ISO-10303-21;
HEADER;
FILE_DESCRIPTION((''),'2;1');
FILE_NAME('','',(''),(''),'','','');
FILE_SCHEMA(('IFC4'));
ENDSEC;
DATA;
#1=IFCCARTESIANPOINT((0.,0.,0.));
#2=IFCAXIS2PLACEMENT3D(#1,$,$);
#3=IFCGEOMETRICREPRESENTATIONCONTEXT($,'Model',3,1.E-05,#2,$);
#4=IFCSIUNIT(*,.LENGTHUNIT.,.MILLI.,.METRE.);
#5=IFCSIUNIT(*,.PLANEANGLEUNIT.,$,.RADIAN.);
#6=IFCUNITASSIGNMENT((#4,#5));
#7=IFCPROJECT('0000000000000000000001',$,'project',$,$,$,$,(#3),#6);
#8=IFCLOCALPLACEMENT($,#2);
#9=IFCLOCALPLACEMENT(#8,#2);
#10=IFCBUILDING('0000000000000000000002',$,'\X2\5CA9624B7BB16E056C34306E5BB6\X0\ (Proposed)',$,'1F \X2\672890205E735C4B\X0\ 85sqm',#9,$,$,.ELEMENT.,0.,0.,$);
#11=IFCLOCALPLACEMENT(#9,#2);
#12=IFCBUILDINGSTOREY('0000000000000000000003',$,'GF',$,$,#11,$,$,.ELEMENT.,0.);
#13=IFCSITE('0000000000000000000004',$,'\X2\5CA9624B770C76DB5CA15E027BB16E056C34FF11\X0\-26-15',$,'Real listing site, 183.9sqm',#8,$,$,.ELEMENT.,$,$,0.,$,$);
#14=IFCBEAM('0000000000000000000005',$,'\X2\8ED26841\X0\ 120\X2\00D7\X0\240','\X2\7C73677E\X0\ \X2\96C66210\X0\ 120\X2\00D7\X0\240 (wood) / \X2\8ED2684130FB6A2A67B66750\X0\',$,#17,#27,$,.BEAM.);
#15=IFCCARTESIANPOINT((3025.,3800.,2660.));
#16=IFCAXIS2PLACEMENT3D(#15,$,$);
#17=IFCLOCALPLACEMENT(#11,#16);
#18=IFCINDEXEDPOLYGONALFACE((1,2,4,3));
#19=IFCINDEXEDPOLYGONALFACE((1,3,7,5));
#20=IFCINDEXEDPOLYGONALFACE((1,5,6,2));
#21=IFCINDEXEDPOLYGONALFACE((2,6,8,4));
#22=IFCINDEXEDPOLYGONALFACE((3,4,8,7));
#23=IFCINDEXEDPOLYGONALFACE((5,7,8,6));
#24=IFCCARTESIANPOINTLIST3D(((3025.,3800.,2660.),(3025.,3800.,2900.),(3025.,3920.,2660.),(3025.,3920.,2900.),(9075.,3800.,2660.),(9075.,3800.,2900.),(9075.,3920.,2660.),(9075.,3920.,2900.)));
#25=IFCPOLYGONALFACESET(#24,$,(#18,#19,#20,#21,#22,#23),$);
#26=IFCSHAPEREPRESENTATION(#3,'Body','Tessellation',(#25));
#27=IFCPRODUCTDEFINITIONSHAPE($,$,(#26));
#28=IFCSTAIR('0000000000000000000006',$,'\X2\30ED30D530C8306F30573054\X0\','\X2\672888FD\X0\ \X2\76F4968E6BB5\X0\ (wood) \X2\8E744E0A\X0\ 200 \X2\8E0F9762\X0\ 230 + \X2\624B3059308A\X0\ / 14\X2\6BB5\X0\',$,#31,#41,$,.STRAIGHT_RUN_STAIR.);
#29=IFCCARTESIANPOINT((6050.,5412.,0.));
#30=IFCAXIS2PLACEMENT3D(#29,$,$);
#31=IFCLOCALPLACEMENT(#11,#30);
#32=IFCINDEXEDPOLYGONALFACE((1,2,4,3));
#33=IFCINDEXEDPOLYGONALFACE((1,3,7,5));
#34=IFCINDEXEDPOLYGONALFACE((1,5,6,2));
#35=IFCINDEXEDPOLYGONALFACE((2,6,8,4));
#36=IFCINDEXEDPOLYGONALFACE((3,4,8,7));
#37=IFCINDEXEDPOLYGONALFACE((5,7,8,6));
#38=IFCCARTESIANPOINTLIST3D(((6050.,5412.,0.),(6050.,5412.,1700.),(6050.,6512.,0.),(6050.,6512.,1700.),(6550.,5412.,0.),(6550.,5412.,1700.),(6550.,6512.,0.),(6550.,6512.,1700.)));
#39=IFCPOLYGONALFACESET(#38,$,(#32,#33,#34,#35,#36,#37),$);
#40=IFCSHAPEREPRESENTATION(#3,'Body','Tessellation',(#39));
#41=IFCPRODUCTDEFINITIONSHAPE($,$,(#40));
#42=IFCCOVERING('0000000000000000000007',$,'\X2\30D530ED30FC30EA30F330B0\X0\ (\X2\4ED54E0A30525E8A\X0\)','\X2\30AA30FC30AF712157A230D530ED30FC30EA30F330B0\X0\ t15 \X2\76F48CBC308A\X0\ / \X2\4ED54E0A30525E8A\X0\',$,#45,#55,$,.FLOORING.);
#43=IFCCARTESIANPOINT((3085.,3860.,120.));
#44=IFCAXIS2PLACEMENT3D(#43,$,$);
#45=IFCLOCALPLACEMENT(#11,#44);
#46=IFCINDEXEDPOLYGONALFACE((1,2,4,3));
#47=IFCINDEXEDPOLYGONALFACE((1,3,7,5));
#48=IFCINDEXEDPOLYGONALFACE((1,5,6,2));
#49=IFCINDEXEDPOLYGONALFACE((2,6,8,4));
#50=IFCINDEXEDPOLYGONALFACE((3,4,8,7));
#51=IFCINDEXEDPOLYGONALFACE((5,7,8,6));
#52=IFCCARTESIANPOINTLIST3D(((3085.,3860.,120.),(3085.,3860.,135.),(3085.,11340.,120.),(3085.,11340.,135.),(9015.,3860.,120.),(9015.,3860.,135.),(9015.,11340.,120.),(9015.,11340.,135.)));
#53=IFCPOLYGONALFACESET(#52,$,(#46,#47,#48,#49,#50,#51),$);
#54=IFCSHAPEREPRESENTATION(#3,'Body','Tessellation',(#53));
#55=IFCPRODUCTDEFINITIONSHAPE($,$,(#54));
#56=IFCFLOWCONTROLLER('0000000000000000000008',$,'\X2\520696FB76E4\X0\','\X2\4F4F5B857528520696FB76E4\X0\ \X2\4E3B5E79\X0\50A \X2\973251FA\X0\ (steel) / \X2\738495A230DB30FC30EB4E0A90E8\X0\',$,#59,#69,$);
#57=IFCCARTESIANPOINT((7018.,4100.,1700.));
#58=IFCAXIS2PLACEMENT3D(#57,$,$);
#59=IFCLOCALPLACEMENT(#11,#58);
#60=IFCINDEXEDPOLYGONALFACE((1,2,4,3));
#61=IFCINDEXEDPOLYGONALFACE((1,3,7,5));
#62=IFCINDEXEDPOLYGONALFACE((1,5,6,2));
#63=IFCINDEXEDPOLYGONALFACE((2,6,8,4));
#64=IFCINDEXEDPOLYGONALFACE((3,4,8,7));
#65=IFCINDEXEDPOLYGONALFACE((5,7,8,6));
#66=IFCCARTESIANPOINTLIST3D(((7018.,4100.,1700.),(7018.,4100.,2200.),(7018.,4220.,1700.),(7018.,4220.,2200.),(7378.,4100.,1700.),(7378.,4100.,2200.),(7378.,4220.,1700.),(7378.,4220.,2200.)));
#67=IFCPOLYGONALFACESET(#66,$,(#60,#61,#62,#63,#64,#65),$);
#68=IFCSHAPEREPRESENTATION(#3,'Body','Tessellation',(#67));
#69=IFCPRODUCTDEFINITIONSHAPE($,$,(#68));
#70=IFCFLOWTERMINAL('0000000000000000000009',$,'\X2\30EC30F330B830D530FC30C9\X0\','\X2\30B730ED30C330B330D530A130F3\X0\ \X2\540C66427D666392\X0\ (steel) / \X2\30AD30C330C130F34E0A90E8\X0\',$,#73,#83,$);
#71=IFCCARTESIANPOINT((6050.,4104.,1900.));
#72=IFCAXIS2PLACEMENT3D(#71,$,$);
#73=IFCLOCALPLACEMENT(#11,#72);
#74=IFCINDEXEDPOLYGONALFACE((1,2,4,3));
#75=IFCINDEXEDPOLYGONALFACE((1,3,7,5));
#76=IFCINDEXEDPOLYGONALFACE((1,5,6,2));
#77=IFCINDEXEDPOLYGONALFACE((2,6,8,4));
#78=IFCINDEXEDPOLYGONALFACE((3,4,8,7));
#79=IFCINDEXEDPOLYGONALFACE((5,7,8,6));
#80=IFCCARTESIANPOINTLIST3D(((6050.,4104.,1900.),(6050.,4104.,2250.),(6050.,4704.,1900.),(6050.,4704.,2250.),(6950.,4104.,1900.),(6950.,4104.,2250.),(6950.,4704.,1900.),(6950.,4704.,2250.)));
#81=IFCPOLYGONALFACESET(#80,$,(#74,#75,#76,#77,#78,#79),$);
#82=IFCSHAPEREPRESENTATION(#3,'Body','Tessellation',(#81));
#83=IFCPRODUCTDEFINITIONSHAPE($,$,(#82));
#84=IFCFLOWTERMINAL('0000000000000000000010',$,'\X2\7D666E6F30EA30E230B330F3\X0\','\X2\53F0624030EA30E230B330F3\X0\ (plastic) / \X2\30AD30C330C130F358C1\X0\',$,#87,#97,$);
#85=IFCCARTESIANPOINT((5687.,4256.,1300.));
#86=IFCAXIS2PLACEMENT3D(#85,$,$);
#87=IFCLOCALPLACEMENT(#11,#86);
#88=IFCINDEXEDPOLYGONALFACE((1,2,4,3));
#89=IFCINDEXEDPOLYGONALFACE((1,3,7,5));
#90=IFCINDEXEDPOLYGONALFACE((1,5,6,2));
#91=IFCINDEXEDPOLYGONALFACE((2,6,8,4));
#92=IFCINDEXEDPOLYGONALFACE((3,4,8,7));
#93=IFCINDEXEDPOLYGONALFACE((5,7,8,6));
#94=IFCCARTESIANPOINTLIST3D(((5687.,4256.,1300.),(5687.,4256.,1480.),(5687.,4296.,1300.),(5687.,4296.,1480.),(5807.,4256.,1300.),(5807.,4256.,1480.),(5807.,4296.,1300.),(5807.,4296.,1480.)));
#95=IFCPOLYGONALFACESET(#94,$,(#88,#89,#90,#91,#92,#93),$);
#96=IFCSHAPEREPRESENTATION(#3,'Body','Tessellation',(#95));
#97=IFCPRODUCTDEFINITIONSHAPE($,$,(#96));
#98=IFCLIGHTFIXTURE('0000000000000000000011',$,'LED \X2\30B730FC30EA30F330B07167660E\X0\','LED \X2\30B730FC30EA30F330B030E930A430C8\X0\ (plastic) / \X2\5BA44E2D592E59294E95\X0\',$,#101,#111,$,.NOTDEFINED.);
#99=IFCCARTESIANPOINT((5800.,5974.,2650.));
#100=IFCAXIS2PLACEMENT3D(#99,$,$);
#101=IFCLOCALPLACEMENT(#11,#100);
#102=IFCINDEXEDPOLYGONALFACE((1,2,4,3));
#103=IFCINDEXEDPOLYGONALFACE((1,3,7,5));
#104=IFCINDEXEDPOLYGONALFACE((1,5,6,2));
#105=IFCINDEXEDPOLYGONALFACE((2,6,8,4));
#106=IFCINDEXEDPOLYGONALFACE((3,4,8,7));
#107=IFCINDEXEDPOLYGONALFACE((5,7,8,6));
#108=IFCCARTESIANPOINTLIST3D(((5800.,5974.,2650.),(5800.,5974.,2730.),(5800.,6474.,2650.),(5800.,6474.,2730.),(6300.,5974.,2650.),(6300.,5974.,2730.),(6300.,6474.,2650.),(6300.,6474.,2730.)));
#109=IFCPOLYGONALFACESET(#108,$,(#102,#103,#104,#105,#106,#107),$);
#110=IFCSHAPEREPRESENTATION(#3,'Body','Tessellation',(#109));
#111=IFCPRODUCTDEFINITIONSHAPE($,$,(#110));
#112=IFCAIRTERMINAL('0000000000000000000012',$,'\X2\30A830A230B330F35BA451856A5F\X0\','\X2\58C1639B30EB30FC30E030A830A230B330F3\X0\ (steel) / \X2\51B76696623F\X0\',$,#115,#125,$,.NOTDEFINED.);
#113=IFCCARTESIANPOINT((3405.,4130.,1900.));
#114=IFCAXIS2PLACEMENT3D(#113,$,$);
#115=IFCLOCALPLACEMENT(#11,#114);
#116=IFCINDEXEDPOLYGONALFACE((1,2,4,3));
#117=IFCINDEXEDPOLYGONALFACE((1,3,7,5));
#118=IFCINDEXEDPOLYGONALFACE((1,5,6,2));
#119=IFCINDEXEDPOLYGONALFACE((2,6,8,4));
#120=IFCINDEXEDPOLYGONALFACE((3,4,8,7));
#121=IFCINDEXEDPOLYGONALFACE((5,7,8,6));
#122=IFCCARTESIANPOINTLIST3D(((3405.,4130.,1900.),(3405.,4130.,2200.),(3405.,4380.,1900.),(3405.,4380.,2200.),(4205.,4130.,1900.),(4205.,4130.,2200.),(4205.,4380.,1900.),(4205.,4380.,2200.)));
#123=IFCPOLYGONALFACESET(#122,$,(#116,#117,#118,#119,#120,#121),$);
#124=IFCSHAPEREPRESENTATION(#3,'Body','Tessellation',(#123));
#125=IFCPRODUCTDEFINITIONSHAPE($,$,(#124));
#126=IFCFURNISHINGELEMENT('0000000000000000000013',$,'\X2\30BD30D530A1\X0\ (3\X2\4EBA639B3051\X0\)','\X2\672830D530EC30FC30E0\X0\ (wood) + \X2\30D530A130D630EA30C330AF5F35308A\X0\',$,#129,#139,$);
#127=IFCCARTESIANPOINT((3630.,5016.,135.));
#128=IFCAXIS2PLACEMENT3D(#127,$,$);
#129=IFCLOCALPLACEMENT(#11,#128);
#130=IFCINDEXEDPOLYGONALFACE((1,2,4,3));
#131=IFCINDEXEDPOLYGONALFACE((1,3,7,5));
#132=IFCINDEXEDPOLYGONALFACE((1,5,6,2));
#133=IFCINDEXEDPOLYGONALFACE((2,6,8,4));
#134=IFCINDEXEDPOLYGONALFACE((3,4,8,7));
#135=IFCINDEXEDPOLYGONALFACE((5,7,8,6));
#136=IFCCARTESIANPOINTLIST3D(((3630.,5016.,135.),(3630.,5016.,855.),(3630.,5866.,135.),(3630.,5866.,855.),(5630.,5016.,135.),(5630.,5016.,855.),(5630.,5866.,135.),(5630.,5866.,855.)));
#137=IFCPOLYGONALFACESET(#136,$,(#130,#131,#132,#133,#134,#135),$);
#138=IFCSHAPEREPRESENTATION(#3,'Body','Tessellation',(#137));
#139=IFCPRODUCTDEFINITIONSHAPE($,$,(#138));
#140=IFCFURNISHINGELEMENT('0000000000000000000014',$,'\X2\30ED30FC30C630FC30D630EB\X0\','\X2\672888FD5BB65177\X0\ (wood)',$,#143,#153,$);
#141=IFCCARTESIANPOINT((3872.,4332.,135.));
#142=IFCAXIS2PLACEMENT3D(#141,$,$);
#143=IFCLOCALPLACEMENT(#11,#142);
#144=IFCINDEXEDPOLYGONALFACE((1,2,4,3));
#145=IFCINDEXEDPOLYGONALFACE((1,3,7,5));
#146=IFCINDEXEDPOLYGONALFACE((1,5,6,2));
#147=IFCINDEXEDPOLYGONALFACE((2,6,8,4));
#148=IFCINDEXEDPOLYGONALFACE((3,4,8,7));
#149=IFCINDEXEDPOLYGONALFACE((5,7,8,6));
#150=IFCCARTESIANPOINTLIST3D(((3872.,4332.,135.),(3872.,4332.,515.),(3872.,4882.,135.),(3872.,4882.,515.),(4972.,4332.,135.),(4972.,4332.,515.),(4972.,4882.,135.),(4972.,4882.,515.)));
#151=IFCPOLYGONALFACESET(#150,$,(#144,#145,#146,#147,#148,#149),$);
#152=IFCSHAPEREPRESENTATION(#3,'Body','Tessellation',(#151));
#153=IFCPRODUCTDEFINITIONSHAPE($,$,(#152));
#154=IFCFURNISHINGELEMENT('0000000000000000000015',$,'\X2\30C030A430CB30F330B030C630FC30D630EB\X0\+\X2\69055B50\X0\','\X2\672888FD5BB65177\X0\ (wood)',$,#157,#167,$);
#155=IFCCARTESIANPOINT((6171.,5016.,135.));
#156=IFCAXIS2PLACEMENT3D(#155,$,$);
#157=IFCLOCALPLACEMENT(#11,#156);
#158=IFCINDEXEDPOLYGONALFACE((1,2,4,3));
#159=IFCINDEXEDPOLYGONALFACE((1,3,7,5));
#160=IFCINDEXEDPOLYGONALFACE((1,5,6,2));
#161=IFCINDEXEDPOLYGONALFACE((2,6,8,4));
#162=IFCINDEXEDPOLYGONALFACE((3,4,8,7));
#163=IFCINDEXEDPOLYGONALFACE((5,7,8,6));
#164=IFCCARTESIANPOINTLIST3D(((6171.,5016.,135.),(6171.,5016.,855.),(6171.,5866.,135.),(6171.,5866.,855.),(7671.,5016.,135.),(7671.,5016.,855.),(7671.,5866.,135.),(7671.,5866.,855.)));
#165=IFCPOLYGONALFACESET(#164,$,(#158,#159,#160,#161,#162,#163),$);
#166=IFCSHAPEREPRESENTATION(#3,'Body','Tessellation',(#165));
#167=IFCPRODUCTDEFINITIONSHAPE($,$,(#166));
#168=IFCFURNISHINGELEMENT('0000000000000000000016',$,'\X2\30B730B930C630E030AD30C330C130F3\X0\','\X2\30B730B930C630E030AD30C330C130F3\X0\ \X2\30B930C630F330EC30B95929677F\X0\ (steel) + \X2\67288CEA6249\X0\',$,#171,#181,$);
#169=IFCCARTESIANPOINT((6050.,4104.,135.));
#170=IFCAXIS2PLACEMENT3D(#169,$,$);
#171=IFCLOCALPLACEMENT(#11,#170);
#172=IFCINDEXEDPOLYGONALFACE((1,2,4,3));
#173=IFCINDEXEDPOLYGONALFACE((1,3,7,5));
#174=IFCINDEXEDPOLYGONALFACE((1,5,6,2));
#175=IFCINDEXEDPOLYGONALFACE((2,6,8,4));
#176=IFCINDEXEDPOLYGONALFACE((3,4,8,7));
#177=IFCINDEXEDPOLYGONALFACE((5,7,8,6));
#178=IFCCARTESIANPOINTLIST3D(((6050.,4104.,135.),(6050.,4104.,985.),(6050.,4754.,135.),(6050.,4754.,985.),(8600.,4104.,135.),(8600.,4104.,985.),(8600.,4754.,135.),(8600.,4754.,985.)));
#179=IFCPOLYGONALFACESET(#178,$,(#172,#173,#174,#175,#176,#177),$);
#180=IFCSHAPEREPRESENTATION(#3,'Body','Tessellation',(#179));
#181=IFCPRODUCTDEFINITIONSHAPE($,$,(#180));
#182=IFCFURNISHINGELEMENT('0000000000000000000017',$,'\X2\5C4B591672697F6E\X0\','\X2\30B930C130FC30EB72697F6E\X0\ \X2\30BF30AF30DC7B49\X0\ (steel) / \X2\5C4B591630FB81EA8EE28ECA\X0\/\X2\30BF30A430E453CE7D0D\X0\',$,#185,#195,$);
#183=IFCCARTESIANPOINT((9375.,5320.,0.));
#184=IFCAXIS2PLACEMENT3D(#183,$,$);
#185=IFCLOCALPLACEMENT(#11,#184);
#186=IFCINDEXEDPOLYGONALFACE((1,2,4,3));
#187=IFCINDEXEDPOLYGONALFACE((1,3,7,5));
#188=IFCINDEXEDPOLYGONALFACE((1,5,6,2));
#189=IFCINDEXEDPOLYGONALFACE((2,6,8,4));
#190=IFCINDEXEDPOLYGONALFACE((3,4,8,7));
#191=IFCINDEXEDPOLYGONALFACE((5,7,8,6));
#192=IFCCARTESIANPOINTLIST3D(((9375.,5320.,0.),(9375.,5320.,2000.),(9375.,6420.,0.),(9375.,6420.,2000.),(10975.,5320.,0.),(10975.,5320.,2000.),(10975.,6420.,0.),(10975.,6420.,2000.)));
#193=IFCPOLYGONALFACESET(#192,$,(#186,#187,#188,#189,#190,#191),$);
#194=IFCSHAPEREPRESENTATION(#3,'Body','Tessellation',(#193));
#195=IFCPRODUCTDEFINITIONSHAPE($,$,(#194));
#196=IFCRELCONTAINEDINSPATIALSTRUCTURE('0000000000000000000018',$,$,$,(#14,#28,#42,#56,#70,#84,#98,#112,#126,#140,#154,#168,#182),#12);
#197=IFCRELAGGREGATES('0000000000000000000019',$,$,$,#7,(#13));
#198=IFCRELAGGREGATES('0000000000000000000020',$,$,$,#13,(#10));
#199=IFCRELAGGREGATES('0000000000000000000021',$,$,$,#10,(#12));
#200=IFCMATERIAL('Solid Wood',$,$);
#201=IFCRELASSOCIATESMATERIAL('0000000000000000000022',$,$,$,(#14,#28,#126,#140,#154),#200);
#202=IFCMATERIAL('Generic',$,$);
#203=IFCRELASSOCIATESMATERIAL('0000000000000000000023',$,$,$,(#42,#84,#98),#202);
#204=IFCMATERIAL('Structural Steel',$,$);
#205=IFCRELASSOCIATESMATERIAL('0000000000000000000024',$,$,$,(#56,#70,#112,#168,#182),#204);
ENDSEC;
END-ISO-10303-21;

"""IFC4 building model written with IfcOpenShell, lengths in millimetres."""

from ifc_helpers import new_model, si_unit, frame, frame_2d, origin, place, context, project, spatial, rectangle, extrude, material, element, save


model = new_model("IFC4")

# Units and contexts
model_context = context("Model", 3, precision=1e-05, world=origin())
ifc_project = project(units=[si_unit("LENGTHUNIT", "METRE", prefix="MILLI"), si_unit("PLANEANGLEUNIT", "RADIAN")], contexts=[model_context])

# Site, building, storey
site_placement = place(None, origin())
site = spatial("IfcSite", under=ifc_project, at=site_placement, Name="岩手県盛岡市箱清水１-26-15", ObjectType="Real listing site, 183.9sqm", CompositionType="ELEMENT", RefElevation=0.0)
building_placement = place(site_placement, origin())
building = spatial("IfcBuilding", under=site, at=building_placement, Name="岩手箱清水の家 (Proposed)", ObjectType="1F 木造平屋 85sqm", CompositionType="ELEMENT", ElevationOfRefHeight=0.0, ElevationOfTerrain=0.0)
storey_placement = place(building_placement, origin())
storey = spatial("IfcBuildingStorey", under=building, at=storey_placement, Name="GF", CompositionType="ELEMENT", Elevation=0.0)

# Beam
ifc_material_1 = material(Name="Solid Wood")
beam_1_placement = place(storey_placement, frame((3025.0, 3800.0, 2660.0)))
element("IfcBeam", 1, at=beam_1_placement, inside=storey, material=ifc_material_1, Name="軒桁 120×240", Description="米松 集成 120×240 (wood) / 軒桁・横架材", PredefinedType="BEAM", context=model_context, shape_type="SweptSolid", body=[
    extrude(rectangle(XDim=6050.0, YDim=120.0, at=frame_2d((3025.0, 60.0))), frame((3025.0, 3800.0, 2660.0)), (0.0, 0.0, 1.0), 240.0),
])

# Stair
stair_placement = place(storey_placement, frame((6050.0, 5412.0, 0.0)))
element("IfcStair", 2, at=stair_placement, inside=storey, material=ifc_material_1, Name="ロフトはしご", Description="木製 直階段 (wood) 蹴上 200 踏面 230 + 手すり / 14段", PredefinedType="STRAIGHT_RUN_STAIR", context=model_context, shape_type="SweptSolid", body=[
    extrude(rectangle(XDim=500.0, YDim=1100.0, at=frame_2d((250.0, 550.0))), frame((6050.0, 5412.0, 0.0)), (0.0, 0.0, 1.0), 1700.0),
])

# Covering
ifc_material_2 = material(Name="Generic")
covering_placement = place(storey_placement, frame((3085.0, 3860.0, 120.0)))
element("IfcCovering", 3, at=covering_placement, inside=storey, material=ifc_material_2, Name="フローリング (仕上げ床)", Description="オーク無垢フローリング t15 直貼り / 仕上げ床", PredefinedType="FLOORING", context=model_context, shape_type="SweptSolid", body=[
    extrude(rectangle(XDim=5930.0, YDim=7480.0, at=frame_2d((2965.0, 3740.0))), frame((3085.0, 3860.0, 120.0)), (0.0, 0.0, 1.0), 15.0),
])

# Flow controller
ifc_material_3 = material(Name="Structural Steel")
flow_controller_placement = place(storey_placement, frame((7018.0, 4100.0, 1700.0)))
element("IfcFlowController", 4, at=flow_controller_placement, inside=storey, material=ifc_material_3, Name="分電盤", Description="住宅用分電盤 主幹50A 露出 (steel) / 玄関ホール上部", context=model_context, shape_type="SweptSolid", body=[
    extrude(rectangle(XDim=360.0, YDim=120.0, at=frame_2d((180.0, 60.0))), frame((7018.0, 4100.0, 1700.0)), (0.0, 0.0, 1.0), 500.0),
])

# Flow terminals
flow_terminal_1_placement = place(storey_placement, frame((6050.0, 4104.0, 1900.0)))
element("IfcFlowTerminal", 5, at=flow_terminal_1_placement, inside=storey, material=ifc_material_3, Name="レンジフード", Description="シロッコファン 同時給排 (steel) / キッチン上部", context=model_context, shape_type="SweptSolid", body=[
    extrude(rectangle(XDim=900.0, YDim=600.0, at=frame_2d((450.0, 300.0))), frame((6050.0, 4104.0, 1900.0)), (0.0, 0.0, 1.0), 350.0),
])
flow_terminal_2_placement = place(storey_placement, frame((5687.0, 4256.0, 1300.0)))
element("IfcFlowTerminal", 6, at=flow_terminal_2_placement, inside=storey, material=ifc_material_2, Name="給湯リモコン", Description="台所リモコン (plastic) / キッチン壁", context=model_context, shape_type="SweptSolid", body=[
    extrude(rectangle(XDim=120.0, YDim=40.0, at=frame_2d((60.0, 20.0))), frame((5687.0, 4256.0, 1300.0)), (0.0, 0.0, 1.0), 180.0),
])

# Light fixture
light_fixture_placement = place(storey_placement, frame((5800.0, 5974.0, 2650.0)))
element("IfcLightFixture", 7, at=light_fixture_placement, inside=storey, material=ifc_material_2, Name="LED シーリング照明", Description="LED シーリングライト (plastic) / 室中央天井", PredefinedType="NOTDEFINED", context=model_context, shape_type="SweptSolid", body=[
    extrude(rectangle(XDim=500.0, YDim=500.0, at=frame_2d((250.0, 250.0))), frame((5800.0, 5974.0, 2650.0)), (0.0, 0.0, 1.0), 80.0),
])

# Air terminal
air_terminal_placement = place(storey_placement, frame((3405.0, 4130.0, 1900.0)))
element("IfcAirTerminal", 8, at=air_terminal_placement, inside=storey, material=ifc_material_3, Name="エアコン室内機", Description="壁掛ルームエアコン (steel) / 冷暖房", PredefinedType="NOTDEFINED", context=model_context, shape_type="SweptSolid", body=[
    extrude(rectangle(XDim=800.0, YDim=250.0, at=frame_2d((400.0, 125.0))), frame((3405.0, 4130.0, 1900.0)), (0.0, 0.0, 1.0), 300.0),
])

# Furnishing elements
furnishing_1_placement = place(storey_placement, frame((3630.0, 5016.0, 135.0)))
element("IfcFurnishingElement", 9, at=furnishing_1_placement, inside=storey, material=ifc_material_1, Name="ソファ (3人掛け)", Description="木フレーム (wood) + ファブリック張り", context=model_context, shape_type="SweptSolid", body=[
    extrude(rectangle(XDim=2000.0, YDim=850.0, at=frame_2d((1000.0, 425.0))), frame((3630.0, 5016.0, 135.0)), (0.0, 0.0, 1.0), 720.0),
])
furnishing_2_placement = place(storey_placement, frame((3872.0, 4332.0, 135.0)))
element("IfcFurnishingElement", 10, at=furnishing_2_placement, inside=storey, material=ifc_material_1, Name="ローテーブル", Description="木製家具 (wood)", context=model_context, shape_type="SweptSolid", body=[
    extrude(rectangle(XDim=1100.0, YDim=550.0, at=frame_2d((550.0, 275.0))), frame((3872.0, 4332.0, 135.0)), (0.0, 0.0, 1.0), 380.0),
])
furnishing_3_placement = place(storey_placement, frame((6171.0, 5016.0, 135.0)))
element("IfcFurnishingElement", 11, at=furnishing_3_placement, inside=storey, material=ifc_material_1, Name="ダイニングテーブル+椅子", Description="木製家具 (wood)", context=model_context, shape_type="SweptSolid", body=[
    extrude(rectangle(XDim=1500.0, YDim=850.0, at=frame_2d((750.0, 425.0))), frame((6171.0, 5016.0, 135.0)), (0.0, 0.0, 1.0), 720.0),
])
furnishing_4_placement = place(storey_placement, frame((6050.0, 4104.0, 135.0)))
element("IfcFurnishingElement", 12, at=furnishing_4_placement, inside=storey, material=ifc_material_3, Name="システムキッチン", Description="システムキッチン ステンレス天板 (steel) + 木質扉", context=model_context, shape_type="SweptSolid", body=[
    extrude(rectangle(XDim=2550.0, YDim=650.0, at=frame_2d((1275.0, 325.0))), frame((6050.0, 4104.0, 135.0)), (0.0, 0.0, 1.0), 850.0),
])
furnishing_5_placement = place(storey_placement, frame((9375.0, 5320.0, 0.0)))
element("IfcFurnishingElement", 13, at=furnishing_5_placement, inside=storey, material=ifc_material_3, Name="屋外物置", Description="スチール物置 タクボ等 (steel) / 屋外・自転車/タイヤ収納", context=model_context, shape_type="SweptSolid", body=[
    extrude(rectangle(XDim=1600.0, YDim=1100.0, at=frame_2d((800.0, 550.0))), frame((9375.0, 5320.0, 0.0)), (0.0, 0.0, 1.0), 2000.0),
])

save(model, "model.ifc")
